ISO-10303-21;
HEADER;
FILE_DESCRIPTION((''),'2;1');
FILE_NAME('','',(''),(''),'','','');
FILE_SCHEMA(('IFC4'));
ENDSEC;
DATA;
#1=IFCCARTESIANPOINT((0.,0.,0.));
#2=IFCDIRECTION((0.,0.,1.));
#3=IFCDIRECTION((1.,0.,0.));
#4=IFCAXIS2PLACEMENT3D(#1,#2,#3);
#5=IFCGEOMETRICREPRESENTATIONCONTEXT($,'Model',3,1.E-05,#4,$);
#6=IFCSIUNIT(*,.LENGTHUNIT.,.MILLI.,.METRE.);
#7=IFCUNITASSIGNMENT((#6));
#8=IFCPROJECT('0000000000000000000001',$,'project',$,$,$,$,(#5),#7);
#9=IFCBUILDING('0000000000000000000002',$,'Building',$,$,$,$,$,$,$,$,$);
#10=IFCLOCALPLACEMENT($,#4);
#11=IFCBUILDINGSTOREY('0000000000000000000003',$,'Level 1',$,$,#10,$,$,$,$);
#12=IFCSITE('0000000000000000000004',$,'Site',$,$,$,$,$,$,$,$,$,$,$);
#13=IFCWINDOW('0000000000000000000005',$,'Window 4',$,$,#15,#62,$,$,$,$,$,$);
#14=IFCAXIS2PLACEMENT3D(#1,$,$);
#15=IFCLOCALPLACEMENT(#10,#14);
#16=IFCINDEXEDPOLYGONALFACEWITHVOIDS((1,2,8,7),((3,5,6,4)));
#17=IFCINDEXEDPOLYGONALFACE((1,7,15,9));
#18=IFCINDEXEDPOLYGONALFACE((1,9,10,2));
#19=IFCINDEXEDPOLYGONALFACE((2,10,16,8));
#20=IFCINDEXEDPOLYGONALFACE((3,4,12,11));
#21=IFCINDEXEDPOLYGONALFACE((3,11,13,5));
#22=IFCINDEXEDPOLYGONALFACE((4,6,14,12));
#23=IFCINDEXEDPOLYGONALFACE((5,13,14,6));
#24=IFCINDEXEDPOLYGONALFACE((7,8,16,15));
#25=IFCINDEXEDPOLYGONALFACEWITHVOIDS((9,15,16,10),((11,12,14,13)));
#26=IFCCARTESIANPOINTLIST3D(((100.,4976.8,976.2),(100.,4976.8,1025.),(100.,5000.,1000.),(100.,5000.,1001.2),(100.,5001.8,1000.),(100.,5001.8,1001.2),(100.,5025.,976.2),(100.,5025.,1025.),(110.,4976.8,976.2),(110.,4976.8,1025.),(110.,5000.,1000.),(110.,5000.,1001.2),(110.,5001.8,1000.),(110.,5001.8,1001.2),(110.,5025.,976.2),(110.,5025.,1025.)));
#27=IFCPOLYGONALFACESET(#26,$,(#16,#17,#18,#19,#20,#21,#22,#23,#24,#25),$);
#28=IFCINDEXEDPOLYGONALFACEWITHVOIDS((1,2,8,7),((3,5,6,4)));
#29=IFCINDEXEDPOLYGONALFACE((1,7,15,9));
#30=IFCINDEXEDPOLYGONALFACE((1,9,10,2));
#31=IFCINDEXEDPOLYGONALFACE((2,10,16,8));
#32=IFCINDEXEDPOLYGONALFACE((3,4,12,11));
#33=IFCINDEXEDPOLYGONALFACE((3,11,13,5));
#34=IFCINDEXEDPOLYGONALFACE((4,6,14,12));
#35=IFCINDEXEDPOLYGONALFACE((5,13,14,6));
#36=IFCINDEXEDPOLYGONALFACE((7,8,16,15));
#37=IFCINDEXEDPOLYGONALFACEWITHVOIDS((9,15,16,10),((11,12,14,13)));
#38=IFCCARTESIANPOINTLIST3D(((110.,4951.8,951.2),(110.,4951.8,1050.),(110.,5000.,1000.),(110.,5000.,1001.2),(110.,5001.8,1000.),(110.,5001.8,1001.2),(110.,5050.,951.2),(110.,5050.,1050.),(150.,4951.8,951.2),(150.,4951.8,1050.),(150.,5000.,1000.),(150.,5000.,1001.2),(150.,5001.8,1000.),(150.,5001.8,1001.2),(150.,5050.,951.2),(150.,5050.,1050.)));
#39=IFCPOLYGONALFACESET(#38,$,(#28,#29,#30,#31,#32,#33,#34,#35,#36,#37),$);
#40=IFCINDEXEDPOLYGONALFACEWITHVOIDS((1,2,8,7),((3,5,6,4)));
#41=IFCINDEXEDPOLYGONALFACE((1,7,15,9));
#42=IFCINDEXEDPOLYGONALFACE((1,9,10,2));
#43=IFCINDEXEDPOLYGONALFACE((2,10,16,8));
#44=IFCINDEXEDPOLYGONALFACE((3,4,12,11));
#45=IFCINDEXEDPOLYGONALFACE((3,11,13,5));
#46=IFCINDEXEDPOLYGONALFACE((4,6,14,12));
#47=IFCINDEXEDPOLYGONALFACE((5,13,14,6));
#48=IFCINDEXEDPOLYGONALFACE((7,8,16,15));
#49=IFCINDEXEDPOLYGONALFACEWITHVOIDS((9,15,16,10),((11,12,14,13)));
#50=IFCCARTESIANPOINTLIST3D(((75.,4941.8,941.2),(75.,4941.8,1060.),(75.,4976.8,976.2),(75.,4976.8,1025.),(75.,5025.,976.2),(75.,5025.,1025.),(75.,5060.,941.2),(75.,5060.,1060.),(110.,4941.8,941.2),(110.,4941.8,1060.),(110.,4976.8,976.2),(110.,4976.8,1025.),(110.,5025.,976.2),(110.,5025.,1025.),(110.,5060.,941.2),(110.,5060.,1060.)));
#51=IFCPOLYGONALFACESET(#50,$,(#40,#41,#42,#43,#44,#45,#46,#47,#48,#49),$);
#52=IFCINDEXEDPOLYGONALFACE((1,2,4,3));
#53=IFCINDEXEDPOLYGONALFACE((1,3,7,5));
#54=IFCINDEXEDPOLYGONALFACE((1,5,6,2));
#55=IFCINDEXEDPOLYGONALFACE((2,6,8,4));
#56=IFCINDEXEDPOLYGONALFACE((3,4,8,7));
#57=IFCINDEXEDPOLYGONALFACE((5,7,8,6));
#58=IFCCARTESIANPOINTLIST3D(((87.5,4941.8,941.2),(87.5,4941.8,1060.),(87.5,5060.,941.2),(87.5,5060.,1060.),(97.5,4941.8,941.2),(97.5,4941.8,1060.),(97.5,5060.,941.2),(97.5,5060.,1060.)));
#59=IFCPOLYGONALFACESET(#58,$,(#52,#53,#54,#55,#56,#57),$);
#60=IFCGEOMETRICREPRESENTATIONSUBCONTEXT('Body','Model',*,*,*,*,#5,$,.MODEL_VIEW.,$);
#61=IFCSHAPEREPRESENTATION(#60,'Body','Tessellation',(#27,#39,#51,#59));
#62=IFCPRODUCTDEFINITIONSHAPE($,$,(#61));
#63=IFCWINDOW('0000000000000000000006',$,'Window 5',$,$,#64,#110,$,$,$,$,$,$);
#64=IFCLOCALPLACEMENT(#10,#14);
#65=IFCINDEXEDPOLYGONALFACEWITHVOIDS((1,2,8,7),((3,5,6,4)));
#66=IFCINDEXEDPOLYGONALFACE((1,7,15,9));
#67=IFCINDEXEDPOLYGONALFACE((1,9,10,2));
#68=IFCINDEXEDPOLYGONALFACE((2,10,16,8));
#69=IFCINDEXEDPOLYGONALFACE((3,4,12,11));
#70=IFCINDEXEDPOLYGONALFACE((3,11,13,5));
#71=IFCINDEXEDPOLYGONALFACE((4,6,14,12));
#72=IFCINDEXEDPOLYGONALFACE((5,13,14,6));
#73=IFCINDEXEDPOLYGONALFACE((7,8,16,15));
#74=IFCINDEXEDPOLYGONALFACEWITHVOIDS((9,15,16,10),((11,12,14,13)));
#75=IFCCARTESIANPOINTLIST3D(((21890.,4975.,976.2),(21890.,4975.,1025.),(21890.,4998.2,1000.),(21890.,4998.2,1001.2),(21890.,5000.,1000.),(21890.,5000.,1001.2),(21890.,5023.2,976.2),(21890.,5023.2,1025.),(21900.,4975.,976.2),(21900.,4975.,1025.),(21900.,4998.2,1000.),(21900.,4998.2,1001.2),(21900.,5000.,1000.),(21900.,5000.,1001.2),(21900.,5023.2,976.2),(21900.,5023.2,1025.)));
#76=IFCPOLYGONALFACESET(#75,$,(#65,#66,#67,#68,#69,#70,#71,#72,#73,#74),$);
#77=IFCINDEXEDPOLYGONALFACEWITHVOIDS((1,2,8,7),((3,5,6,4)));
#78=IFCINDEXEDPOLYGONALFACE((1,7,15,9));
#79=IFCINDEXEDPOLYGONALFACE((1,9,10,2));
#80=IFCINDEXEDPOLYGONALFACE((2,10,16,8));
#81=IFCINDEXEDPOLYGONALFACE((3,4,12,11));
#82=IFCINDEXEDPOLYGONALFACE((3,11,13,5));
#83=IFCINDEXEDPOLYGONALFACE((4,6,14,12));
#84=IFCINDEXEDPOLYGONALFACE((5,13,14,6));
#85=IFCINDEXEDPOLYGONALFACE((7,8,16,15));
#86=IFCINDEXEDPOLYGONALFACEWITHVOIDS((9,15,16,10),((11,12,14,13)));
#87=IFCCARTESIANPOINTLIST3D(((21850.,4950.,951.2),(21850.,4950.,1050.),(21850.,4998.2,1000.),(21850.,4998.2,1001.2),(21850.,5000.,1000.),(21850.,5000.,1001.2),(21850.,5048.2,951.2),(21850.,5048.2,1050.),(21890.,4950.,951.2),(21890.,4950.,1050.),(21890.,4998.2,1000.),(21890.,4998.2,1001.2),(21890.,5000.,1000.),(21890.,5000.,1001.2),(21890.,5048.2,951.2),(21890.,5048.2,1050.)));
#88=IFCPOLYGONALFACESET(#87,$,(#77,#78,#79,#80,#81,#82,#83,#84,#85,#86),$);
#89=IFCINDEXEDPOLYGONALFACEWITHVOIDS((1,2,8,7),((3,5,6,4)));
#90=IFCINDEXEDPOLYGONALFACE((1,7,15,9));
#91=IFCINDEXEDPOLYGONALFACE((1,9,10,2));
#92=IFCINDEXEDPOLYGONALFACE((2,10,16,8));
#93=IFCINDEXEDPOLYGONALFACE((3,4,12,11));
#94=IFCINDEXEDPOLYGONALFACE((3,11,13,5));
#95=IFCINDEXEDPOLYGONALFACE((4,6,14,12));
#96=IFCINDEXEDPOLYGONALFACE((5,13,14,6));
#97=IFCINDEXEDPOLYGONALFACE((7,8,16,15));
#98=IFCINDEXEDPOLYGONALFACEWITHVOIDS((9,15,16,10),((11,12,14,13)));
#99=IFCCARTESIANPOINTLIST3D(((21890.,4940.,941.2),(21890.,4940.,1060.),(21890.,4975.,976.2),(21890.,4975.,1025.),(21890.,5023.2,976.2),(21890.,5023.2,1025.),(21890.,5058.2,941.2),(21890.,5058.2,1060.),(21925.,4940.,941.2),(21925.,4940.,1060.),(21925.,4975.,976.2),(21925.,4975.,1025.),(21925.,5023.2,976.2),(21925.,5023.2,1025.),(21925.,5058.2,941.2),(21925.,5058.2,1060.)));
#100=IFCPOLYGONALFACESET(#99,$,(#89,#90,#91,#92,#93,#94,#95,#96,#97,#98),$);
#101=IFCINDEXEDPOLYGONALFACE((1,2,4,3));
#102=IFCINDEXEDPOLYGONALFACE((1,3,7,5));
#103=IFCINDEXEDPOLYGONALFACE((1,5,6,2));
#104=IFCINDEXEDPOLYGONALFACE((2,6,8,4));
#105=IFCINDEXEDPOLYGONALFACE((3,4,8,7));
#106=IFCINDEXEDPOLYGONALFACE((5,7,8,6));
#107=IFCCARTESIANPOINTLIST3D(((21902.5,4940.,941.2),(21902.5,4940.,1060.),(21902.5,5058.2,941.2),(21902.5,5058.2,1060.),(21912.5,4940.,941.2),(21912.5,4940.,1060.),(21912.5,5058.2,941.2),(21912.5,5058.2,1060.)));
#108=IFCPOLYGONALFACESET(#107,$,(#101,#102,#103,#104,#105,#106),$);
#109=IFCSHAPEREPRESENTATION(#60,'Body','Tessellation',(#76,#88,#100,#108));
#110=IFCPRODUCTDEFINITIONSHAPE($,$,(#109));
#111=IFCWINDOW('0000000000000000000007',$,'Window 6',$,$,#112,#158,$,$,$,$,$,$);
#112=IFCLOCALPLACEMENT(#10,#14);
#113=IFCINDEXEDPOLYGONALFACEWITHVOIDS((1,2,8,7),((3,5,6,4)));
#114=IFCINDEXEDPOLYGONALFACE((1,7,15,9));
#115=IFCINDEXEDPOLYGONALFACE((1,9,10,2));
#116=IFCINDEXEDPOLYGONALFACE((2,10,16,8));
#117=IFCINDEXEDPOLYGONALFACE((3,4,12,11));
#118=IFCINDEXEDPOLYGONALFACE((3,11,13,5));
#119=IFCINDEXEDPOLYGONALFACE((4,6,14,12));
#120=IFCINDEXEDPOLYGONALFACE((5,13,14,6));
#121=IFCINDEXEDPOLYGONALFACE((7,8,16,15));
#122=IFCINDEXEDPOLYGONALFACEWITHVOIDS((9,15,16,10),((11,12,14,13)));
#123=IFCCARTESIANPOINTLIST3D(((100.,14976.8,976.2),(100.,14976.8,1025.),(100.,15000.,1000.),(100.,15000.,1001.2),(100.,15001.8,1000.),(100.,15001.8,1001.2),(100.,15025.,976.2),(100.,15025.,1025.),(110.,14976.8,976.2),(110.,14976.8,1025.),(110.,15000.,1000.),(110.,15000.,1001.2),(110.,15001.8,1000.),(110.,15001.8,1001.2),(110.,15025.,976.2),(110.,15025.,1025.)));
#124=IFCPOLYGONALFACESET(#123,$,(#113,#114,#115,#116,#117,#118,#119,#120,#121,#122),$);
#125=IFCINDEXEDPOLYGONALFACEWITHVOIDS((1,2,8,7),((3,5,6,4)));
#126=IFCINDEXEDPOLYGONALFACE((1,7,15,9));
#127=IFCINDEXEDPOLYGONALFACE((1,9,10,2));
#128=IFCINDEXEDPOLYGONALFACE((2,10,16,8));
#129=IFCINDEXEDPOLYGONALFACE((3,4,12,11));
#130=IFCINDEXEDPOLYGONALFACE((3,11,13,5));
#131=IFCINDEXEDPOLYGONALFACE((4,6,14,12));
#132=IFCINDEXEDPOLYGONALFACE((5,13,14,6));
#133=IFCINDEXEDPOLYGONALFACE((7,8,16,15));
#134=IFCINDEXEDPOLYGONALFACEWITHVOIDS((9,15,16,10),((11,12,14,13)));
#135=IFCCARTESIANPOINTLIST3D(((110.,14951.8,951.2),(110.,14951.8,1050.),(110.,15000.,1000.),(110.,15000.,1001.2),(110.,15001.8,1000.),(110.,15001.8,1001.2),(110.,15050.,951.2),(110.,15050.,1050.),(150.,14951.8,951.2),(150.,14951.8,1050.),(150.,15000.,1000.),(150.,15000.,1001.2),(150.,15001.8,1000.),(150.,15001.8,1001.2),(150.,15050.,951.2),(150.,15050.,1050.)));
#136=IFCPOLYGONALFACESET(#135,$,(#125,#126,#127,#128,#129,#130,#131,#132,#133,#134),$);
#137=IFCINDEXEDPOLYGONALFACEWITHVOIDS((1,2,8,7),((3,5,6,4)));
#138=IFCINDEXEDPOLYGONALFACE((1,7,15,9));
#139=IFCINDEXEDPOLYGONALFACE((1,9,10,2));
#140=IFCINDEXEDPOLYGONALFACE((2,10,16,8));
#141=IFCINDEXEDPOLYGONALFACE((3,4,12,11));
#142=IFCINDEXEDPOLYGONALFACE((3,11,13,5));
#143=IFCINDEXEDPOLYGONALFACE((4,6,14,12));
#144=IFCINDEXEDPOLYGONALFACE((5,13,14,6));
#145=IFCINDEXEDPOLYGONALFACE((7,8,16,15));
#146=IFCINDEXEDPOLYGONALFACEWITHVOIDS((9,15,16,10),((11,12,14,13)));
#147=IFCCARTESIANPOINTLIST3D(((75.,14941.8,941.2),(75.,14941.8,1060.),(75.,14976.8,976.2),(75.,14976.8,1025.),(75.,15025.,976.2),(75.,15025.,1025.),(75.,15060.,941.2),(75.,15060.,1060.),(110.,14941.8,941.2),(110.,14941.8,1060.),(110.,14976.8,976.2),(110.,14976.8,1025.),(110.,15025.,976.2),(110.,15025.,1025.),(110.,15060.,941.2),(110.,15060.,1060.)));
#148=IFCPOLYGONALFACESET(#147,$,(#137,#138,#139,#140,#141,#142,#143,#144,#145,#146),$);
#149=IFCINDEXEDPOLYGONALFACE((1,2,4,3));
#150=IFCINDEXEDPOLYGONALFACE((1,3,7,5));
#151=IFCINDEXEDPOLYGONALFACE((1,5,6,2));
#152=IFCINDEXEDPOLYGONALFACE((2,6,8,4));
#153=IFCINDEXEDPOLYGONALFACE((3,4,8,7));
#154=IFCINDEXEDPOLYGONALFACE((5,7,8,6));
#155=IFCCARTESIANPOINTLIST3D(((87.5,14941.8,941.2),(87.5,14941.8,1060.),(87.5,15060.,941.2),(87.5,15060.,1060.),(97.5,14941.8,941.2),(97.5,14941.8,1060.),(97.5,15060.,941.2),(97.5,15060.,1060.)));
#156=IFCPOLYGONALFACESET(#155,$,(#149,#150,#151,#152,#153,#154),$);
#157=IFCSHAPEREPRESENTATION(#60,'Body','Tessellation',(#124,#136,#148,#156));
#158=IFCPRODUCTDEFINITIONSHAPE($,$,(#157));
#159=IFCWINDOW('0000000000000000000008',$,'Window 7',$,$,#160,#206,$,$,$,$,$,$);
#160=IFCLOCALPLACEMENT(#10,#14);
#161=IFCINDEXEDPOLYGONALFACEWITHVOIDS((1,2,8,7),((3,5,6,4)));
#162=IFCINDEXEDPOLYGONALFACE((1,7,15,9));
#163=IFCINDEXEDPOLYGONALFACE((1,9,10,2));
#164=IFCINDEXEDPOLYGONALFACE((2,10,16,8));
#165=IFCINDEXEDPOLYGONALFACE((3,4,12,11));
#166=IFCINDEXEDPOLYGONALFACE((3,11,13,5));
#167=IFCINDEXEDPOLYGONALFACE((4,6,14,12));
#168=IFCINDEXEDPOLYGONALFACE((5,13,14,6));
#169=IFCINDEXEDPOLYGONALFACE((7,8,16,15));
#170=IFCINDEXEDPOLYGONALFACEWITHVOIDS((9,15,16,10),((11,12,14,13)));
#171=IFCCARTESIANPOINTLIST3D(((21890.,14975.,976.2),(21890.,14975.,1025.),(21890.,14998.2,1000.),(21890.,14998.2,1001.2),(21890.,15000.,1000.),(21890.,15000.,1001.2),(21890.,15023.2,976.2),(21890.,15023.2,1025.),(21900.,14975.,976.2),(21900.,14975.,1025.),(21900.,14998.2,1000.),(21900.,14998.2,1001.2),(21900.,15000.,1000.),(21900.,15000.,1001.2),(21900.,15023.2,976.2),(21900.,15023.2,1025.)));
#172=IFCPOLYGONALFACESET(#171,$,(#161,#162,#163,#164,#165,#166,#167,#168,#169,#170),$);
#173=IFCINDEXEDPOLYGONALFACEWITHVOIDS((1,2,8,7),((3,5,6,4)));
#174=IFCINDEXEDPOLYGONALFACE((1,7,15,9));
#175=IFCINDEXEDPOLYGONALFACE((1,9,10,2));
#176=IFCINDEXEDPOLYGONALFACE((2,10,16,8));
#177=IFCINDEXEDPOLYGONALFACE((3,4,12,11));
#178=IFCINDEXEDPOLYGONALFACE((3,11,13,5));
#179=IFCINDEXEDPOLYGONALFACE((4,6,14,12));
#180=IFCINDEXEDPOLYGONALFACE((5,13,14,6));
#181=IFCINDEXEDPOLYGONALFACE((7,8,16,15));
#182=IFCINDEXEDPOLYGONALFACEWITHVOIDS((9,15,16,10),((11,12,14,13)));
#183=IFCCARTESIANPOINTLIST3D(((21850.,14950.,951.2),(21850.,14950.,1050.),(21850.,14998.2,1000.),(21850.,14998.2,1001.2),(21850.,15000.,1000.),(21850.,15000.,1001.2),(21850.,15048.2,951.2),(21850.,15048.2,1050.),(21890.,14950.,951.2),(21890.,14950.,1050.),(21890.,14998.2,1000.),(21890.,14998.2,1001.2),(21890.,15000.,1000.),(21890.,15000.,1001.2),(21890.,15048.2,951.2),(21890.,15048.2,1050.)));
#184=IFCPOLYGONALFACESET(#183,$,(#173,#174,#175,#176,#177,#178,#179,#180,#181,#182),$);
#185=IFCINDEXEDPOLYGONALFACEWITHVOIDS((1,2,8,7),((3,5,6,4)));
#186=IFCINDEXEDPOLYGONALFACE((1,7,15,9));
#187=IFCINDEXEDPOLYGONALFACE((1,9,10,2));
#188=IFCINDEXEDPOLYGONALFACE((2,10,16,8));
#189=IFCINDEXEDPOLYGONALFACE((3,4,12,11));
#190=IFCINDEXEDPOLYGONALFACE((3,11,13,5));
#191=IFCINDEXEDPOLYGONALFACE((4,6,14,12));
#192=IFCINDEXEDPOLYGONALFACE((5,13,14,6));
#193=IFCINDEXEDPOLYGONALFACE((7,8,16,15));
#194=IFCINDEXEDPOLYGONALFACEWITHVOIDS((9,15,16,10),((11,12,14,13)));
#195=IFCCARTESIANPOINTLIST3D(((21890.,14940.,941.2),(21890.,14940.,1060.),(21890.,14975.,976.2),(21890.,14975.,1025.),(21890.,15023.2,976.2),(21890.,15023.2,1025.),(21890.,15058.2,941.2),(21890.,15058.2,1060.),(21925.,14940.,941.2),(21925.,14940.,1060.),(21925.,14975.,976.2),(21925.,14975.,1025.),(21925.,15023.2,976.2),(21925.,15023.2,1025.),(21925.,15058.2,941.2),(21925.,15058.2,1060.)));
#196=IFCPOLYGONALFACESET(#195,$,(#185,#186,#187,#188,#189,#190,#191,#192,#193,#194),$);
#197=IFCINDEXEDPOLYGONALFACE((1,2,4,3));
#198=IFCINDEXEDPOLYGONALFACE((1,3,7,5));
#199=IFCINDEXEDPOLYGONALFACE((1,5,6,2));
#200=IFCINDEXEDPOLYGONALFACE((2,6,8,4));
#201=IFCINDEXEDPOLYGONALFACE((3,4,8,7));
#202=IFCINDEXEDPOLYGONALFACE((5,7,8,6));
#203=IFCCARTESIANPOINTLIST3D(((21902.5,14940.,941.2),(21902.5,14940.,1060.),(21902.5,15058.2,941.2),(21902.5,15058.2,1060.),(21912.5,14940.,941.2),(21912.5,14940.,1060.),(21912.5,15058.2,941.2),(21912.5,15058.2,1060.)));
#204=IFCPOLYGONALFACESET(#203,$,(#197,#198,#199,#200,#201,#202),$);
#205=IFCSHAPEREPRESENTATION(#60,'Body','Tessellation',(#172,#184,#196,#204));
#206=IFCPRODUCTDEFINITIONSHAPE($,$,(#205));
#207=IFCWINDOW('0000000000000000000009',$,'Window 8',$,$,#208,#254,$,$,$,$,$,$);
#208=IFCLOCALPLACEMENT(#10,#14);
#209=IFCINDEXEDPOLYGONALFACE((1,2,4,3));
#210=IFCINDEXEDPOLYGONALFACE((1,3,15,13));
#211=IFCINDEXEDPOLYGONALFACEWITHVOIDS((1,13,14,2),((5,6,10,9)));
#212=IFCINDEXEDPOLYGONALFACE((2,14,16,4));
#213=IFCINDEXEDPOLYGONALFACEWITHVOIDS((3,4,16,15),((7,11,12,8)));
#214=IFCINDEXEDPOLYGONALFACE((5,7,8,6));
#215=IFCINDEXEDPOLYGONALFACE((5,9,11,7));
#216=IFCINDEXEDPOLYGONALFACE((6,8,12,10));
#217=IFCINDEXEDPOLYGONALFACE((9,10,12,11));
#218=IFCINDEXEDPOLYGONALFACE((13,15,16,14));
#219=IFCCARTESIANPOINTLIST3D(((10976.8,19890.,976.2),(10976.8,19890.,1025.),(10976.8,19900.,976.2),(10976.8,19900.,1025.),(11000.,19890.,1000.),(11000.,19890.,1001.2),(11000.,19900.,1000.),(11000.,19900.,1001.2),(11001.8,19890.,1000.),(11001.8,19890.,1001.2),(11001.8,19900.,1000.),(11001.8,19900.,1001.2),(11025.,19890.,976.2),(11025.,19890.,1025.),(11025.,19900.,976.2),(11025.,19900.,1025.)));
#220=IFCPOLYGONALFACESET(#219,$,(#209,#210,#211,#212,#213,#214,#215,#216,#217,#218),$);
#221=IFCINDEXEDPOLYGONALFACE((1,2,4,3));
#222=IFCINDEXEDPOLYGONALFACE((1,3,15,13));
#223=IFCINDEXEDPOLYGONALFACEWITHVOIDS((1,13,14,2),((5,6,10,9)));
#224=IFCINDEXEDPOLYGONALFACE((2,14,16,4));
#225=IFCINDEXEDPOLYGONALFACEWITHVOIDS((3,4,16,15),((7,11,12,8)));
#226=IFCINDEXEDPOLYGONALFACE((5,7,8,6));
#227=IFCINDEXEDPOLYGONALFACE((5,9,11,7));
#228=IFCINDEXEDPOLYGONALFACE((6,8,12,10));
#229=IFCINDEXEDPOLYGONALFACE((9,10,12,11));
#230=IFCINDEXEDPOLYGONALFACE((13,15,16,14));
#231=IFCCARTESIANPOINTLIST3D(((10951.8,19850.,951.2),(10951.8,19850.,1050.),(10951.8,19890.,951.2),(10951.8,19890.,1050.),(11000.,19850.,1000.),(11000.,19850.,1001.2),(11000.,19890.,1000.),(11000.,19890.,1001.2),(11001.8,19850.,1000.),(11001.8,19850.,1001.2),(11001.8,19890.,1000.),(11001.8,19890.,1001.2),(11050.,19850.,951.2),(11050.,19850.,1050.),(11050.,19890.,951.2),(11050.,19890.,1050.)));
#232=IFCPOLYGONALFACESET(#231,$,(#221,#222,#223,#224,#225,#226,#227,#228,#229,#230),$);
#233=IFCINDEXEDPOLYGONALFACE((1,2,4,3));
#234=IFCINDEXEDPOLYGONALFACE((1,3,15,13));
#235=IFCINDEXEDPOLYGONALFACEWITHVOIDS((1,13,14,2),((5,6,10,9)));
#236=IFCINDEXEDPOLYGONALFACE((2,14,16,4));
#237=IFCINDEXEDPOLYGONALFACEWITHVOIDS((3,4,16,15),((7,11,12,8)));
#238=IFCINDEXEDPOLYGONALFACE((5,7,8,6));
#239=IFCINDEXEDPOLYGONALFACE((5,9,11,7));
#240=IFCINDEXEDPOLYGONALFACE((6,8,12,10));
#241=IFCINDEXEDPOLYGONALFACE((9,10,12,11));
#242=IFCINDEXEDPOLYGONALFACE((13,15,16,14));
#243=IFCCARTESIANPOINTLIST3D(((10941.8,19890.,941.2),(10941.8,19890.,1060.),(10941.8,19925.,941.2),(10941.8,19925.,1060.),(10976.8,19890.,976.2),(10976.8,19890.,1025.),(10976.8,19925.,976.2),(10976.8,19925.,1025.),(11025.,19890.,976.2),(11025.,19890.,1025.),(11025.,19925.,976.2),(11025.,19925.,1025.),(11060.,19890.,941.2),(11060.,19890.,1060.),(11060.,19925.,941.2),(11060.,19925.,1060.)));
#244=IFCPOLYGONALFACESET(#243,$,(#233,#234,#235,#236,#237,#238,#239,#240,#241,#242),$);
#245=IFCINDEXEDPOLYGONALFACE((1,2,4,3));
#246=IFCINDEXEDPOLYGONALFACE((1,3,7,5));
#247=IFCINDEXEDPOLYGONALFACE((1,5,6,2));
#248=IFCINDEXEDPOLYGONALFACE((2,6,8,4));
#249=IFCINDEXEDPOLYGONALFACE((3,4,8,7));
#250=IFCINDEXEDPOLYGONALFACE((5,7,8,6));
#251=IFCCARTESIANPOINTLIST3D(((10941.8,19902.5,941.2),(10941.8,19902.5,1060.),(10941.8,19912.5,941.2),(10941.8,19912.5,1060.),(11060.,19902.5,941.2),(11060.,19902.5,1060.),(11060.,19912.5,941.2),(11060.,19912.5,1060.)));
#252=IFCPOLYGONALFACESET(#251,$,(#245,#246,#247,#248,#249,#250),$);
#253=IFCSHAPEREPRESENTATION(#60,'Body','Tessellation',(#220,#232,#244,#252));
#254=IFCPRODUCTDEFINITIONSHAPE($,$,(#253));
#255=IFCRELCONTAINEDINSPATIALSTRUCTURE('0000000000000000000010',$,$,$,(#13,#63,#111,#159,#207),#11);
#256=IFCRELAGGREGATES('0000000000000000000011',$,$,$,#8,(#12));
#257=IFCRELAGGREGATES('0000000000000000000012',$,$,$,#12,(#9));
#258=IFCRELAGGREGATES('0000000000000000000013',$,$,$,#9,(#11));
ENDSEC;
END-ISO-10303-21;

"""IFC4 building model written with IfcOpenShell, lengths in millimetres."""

from ifc_helpers import new_model, si_unit, frame, origin_with_axes, place, context, subcontext, project, spatial, line, indexed_curve, outline, extrude, element, save


model = new_model("IFC4")

# Units and contexts
model_context = context("Model", 3, precision=1e-05, world=origin_with_axes())
body_context = subcontext(model_context, "Body", "Model", "MODEL_VIEW")
ifc_project = project(units=[si_unit("LENGTHUNIT", "METRE", prefix="MILLI")], contexts=[model_context])

# Site, building, storey
site = spatial("IfcSite", under=ifc_project, Name="Site")
building = spatial("IfcBuilding", under=site, Name="Building")
storey_placement = place(None, origin_with_axes())
storey = spatial("IfcBuildingStorey", under=building, at=storey_placement, Name="Level 1")

# Windows
for number, where, z_axis, x_axis, name in (
    (1, (200.0, 5000.0, 1000.0), (0.0, 0.0, 1.0), (0.0, 1.0, 0.0), "Window 4"),
    (2, (21800.0, 5000.0, 1000.0), (0.0, 0.0, 1.0), (0.0, -1.0, 0.0), "Window 5"),
    (3, (200.0, 15000.0, 1000.0), (0.0, 0.0, 1.0), (0.0, 1.0, 0.0), "Window 6"),
    (4, (21800.0, 15000.0, 1000.0), (0.0, 0.0, 1.0), (0.0, -1.0, 0.0), "Window 7"),
    (5, (11000.0, 19800.0, 1000.0), (0.0, 0.0, 1.0), (1.0, 0.0, 0.0), "Window 8"),
):
    element("IfcWindow", number, at=place(storey_placement, frame(where, z_axis=z_axis, x_axis=x_axis)), inside=storey, Name=name, context=body_context, shape_type="SweptSolid", body=[
        extrude(outline(indexed_curve([(0.0, 0.0), (1.8, 0.0), (1.8, 1.2), (0.0, 1.2)], segments=[line(1, 2, 3, 4, 1)]), holes=[indexed_curve([(25.0, 25.0), (-23.2, 25.0), (-23.2, -23.8), (25.0, -23.8)], segments=[line(1, 2, 3, 4, 1)])]), frame((0.0, 90.0, 0.0), z_axis=(0.0, -1.0, 0.0), x_axis=(1.0, 0.0, 0.0)), (0.0, 0.0, -1.0), 10.0),
        extrude(outline(indexed_curve([(0.0, 0.0), (1.8, 0.0), (1.8, 1.2), (0.0, 1.2)], segments=[line(1, 2, 3, 4, 1)]), holes=[indexed_curve([(50.0, 50.0), (-48.2, 50.0), (-48.2, -48.8), (50.0, -48.8)], segments=[line(1, 2, 3, 4, 1)])]), frame((0.0, 50.0, 0.0), z_axis=(0.0, -1.0, 0.0), x_axis=(1.0, 0.0, 0.0)), (0.0, 0.0, -1.0), 40.0),
        extrude(outline(indexed_curve([(0.0, 0.0), (-48.2, 0.0), (-48.2, -48.8), (0.0, -48.8)], segments=[line(1, 2, 3, 4, 1)]), holes=[indexed_curve([(35.0, 35.0), (-83.2, 35.0), (-83.2, -83.8), (35.0, -83.8)], segments=[line(1, 2, 3, 4, 1)])]), frame((25.0, 90.0, 25.0), z_axis=(0.0, -1.0, 0.0), x_axis=(1.0, 0.0, 0.0)), (0.0, 0.0, -1.0), 35.0),
        extrude(outline(indexed_curve([(35.0, 35.0), (-83.2, 35.0), (-83.2, -83.8), (35.0, -83.8)], segments=[line(1, 2, 3, 4, 1)])), frame((25.0, 102.5, 25.0), z_axis=(0.0, -1.0, 0.0), x_axis=(1.0, 0.0, 0.0)), (0.0, 0.0, -1.0), 10.0),
    ])

save(model, "model.ifc")
